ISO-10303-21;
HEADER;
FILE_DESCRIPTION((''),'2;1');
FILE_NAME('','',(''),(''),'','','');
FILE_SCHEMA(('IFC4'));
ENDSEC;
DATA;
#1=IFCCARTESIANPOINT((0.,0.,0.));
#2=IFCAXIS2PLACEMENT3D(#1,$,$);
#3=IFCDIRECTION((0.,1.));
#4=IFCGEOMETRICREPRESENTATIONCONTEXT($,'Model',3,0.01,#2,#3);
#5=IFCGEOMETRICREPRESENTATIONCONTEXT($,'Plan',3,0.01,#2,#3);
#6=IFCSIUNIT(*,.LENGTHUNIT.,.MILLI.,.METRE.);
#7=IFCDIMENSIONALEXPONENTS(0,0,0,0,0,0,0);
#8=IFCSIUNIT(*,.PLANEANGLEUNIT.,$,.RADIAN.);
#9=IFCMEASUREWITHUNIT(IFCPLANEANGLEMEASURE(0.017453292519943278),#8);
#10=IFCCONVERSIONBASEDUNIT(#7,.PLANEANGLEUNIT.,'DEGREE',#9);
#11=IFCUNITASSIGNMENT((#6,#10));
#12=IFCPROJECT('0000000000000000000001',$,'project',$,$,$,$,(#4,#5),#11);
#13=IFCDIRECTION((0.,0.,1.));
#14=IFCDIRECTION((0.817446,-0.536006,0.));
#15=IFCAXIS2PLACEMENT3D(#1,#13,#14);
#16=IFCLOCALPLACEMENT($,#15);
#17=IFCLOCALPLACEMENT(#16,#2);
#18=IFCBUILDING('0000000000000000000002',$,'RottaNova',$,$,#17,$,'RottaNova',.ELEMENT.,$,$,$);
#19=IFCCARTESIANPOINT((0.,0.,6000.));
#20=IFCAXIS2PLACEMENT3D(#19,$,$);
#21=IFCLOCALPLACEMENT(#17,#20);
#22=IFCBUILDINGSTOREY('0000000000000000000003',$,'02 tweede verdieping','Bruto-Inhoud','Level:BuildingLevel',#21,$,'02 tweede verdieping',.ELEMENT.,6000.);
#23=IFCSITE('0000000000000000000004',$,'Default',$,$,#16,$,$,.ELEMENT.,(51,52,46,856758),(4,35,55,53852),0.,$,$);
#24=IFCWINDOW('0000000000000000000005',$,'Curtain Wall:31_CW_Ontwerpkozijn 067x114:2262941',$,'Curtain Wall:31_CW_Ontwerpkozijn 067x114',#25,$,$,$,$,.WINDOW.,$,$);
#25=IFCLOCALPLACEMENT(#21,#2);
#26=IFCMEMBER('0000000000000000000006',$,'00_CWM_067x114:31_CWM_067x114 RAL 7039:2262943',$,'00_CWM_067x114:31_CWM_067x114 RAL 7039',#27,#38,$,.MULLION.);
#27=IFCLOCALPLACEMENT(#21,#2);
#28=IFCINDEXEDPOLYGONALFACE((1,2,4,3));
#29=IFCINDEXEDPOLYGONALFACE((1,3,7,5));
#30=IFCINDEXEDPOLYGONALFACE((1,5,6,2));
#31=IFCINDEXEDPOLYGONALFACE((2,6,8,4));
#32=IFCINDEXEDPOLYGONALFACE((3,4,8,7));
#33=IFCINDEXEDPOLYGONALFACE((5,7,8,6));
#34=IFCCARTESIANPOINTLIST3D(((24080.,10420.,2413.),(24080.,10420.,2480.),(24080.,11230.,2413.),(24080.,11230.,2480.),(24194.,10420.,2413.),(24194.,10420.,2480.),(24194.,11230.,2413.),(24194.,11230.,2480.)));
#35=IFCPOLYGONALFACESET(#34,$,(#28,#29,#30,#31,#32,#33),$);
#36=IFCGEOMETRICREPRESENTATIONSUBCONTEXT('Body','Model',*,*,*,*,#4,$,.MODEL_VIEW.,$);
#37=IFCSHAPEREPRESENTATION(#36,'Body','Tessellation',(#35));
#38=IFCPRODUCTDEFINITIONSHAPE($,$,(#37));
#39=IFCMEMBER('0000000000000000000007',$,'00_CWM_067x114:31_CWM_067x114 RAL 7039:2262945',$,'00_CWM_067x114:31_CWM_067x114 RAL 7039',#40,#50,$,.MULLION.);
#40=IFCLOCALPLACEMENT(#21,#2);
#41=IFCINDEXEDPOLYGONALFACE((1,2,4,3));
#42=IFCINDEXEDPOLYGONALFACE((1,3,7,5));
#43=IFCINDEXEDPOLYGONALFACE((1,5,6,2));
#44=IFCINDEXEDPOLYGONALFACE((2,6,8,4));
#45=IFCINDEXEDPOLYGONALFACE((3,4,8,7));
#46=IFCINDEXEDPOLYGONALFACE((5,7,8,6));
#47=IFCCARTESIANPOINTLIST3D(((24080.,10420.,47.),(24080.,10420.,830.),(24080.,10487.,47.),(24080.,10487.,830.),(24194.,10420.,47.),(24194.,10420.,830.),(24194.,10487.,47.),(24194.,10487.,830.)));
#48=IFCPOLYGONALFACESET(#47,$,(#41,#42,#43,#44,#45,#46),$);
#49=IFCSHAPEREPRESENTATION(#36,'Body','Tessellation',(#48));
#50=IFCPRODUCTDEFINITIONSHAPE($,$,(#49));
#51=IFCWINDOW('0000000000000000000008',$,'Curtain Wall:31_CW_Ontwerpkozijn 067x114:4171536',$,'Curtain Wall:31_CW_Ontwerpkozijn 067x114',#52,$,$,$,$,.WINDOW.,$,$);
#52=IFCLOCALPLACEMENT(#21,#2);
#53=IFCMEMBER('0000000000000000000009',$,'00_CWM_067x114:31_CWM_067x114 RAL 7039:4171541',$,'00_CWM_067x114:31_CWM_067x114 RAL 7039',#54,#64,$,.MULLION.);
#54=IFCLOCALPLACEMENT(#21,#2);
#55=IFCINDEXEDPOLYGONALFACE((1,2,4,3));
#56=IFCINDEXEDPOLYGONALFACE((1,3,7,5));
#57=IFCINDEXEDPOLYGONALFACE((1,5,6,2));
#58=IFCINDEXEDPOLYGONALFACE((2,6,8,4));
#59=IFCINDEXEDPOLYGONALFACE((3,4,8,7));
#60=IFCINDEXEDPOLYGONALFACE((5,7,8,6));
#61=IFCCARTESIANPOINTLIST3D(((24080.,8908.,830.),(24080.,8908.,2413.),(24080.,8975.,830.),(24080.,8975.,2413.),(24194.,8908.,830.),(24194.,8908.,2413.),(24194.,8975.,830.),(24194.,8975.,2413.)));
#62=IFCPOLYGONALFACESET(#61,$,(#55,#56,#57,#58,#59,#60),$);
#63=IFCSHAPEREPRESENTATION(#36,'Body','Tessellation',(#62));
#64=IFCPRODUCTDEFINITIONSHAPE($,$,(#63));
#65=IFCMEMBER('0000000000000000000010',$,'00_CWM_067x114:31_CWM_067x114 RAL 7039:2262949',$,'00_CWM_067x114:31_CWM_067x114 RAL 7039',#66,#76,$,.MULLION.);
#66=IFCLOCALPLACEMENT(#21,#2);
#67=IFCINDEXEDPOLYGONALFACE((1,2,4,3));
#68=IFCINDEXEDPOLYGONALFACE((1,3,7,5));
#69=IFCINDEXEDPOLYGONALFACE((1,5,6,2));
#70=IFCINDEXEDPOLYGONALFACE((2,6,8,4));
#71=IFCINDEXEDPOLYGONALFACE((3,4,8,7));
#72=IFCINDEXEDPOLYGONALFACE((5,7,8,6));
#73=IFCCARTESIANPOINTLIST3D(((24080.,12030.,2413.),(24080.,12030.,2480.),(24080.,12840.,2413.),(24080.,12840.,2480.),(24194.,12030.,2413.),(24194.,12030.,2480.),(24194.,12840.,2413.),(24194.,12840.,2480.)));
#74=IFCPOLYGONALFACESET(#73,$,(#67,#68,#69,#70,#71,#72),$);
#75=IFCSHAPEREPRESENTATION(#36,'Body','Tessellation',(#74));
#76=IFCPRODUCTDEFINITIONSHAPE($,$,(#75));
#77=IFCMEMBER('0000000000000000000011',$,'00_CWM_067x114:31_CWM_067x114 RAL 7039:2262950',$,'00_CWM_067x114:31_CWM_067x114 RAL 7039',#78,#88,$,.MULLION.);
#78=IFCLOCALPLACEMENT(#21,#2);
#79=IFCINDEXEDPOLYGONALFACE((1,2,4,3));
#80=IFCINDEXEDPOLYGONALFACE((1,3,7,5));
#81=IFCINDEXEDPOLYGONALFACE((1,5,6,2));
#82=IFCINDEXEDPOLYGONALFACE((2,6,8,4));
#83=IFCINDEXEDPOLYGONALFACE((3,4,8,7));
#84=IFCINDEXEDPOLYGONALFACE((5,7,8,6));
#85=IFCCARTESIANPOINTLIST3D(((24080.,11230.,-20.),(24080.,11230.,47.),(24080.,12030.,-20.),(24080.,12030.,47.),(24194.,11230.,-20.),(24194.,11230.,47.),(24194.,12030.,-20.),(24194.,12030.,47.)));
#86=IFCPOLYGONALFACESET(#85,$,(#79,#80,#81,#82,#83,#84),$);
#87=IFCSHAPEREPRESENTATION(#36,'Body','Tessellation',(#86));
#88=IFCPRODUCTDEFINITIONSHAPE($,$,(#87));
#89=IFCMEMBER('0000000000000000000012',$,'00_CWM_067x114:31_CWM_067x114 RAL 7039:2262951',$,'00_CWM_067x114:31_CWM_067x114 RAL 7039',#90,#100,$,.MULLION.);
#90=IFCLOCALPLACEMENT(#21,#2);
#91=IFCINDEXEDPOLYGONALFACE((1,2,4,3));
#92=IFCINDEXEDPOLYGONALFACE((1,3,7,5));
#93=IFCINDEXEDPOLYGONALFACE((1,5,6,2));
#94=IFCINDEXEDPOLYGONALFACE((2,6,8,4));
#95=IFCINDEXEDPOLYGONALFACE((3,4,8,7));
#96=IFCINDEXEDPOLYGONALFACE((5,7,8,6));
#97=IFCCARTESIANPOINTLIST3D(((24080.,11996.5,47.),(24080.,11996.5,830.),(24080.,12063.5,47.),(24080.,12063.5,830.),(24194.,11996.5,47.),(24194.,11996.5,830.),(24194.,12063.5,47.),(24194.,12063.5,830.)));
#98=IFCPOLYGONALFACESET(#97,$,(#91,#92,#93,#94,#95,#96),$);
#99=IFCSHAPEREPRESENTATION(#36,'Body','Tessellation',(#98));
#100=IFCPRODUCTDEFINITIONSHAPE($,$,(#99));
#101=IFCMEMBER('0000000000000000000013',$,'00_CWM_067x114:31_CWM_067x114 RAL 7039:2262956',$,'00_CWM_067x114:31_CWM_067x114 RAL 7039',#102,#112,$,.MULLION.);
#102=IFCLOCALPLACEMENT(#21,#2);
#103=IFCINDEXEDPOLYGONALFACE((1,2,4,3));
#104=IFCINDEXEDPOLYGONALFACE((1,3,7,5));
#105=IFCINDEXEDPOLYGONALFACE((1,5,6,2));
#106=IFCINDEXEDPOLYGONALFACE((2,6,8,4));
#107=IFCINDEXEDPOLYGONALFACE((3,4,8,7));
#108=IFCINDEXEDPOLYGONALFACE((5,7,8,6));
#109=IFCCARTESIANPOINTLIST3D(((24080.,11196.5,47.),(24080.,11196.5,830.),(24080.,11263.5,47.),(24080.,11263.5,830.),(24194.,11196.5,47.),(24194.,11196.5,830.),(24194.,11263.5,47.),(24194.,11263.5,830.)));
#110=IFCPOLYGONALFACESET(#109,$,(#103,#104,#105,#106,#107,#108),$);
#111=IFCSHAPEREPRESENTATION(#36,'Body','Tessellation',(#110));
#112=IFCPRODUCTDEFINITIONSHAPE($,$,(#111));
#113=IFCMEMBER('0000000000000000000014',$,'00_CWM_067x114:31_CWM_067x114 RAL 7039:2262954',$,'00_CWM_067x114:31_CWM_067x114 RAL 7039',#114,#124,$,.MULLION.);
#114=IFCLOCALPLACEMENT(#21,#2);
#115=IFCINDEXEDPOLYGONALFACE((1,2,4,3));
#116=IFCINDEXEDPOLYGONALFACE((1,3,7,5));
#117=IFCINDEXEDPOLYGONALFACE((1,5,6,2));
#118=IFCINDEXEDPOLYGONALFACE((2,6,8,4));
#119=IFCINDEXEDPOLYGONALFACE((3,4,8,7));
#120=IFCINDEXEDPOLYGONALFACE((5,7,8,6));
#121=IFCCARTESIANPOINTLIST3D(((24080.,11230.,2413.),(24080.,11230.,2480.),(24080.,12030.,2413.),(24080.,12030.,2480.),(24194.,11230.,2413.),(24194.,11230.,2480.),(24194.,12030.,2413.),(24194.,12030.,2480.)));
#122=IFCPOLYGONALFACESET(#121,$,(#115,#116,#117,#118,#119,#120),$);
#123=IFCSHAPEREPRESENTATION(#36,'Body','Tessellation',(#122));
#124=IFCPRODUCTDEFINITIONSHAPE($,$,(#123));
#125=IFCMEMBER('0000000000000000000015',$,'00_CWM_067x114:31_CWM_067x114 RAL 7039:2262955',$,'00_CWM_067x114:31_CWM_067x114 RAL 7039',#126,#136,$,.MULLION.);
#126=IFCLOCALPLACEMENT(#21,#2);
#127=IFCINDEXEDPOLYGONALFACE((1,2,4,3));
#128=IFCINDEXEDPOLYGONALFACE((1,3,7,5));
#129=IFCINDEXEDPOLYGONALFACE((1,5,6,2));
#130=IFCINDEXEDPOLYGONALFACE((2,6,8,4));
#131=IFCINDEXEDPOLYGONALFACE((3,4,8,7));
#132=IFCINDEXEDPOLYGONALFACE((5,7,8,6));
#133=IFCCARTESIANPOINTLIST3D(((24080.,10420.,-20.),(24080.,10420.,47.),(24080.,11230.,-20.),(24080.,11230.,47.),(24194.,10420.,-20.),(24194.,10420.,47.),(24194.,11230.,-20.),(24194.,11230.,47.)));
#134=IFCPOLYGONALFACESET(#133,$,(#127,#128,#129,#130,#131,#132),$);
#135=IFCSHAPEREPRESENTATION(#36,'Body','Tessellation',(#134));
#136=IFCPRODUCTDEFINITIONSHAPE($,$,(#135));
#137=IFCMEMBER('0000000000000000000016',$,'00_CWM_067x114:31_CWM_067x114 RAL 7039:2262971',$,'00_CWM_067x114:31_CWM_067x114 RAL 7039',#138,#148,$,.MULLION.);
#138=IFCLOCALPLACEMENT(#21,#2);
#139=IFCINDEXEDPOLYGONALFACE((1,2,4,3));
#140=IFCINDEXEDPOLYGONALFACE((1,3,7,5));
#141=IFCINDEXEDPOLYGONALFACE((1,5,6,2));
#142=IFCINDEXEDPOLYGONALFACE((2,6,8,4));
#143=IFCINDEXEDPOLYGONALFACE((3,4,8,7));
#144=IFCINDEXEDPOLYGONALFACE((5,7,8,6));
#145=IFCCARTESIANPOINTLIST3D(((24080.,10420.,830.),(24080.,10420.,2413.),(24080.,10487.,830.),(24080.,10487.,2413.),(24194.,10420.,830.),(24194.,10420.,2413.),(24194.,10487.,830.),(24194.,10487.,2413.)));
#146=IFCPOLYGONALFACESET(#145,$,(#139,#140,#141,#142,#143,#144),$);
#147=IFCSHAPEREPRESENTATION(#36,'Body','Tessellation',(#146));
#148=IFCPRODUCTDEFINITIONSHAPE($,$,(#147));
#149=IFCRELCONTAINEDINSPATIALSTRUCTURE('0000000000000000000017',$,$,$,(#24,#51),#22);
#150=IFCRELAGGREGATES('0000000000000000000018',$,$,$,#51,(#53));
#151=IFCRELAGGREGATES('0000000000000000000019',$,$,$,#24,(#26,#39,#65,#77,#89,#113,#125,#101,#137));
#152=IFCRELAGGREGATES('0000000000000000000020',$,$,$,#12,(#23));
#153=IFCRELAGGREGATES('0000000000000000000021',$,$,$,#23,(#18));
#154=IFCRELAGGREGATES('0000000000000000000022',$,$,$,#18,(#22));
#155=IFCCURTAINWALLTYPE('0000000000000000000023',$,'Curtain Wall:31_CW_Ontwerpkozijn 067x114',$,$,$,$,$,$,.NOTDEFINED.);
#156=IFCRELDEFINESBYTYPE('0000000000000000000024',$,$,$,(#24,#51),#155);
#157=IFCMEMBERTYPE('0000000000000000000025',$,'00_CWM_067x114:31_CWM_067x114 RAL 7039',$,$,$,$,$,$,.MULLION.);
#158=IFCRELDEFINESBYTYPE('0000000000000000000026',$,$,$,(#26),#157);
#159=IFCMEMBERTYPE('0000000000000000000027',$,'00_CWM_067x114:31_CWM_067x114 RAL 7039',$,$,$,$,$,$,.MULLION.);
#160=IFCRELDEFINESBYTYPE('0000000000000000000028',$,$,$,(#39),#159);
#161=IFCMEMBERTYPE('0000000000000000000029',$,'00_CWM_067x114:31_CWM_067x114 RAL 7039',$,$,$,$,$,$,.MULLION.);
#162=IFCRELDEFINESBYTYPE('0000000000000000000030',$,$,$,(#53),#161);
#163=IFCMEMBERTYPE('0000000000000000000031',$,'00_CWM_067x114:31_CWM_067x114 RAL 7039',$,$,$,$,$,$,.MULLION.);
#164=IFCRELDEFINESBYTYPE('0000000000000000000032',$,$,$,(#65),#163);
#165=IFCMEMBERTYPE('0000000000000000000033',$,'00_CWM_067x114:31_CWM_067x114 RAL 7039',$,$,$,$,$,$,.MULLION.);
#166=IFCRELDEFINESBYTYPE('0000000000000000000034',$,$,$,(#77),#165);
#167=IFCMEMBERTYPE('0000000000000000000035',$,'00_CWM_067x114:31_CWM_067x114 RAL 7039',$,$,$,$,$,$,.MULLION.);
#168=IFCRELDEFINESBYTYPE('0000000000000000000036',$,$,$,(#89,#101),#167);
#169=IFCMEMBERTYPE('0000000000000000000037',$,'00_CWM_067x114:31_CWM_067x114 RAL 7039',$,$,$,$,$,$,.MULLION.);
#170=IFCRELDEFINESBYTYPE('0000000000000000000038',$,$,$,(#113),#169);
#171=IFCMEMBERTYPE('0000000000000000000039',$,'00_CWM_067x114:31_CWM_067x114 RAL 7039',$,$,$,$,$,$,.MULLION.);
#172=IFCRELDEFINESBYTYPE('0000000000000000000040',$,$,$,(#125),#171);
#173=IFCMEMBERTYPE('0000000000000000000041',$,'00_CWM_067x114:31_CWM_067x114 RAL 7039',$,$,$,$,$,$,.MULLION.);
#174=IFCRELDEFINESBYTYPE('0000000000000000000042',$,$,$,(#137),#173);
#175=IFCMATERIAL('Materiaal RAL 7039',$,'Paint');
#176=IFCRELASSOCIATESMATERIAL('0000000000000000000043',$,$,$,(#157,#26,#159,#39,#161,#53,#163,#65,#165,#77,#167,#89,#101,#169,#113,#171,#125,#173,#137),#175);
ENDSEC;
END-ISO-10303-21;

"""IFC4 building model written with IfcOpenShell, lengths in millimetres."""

from ifc_helpers import new_model, entity, si_unit, converted_unit, direction, frame, origin, place, context, subcontext, project, spatial, indexed_curve, outline, extrude, source, transform, mapped, material, type_object, type_shapes, element, aggregate, save


model = new_model("IFC4")

# Units and contexts
model_context = context("Model", 3, precision=0.01, world=origin(), true_north=direction((0.0, 1.0)))
plan_context = context("Plan", 3, precision=0.01, world=origin(), true_north=direction((0.0, 1.0)))
body_context = subcontext(model_context, "Body", "Model", "MODEL_VIEW")
ifc_project = project(units=[si_unit("LENGTHUNIT", "METRE", prefix="MILLI"), converted_unit("PLANEANGLEUNIT", "DEGREE", entity("IfcPlaneAngleMeasure", 0.017453292519943278), si_unit("PLANEANGLEUNIT", "RADIAN"), dimensions=[0, 0, 0, 0, 0, 0, 0])], contexts=[model_context, plan_context])

# Site, building, storey
site_placement = place(None, frame((0.0, 0.0, 0.0), z_axis=(0.0, 0.0, 1.0), x_axis=(0.817446, -0.536006, 0.0)))
site = spatial("IfcSite", under=ifc_project, at=site_placement, Name="Default", CompositionType="ELEMENT", RefLatitude=(51, 52, 46, 856758), RefLongitude=(4, 35, 55, 53852), RefElevation=0.0)
building_placement = place(site_placement, origin())
building = spatial("IfcBuilding", under=site, at=building_placement, Name="RottaNova", LongName="RottaNova", CompositionType="ELEMENT")
storey_placement = place(building_placement, frame((0.0, 0.0, 6000.0)))
storey = spatial("IfcBuildingStorey", under=building, at=storey_placement, Name="02 tweede verdieping", Description="Bruto-Inhoud", ObjectType="Level:BuildingLevel", LongName="02 tweede verdieping", CompositionType="ELEMENT", Elevation=6000.0)

# Window, members
curtain_wall_type = type_object("IfcCurtainWallType", Name="Curtain Wall:31_CW_Ontwerpkozijn 067x114", PredefinedType="NOTDEFINED")
window_1_placement = place(storey_placement, frame((0.0, 0.0, -6000.0)))
window_1 = element("IfcWindow", 1, at=window_1_placement, inside=storey, type_object=curtain_wall_type, Name="Curtain Wall:31_CW_Ontwerpkozijn 067x114:2262941", ObjectType="Curtain Wall:31_CW_Ontwerpkozijn 067x114", PredefinedType="WINDOW")
ifc_material_1 = material(Name="Materiaal RAL 7039", Category="Paint")
member_type_1 = type_object("IfcMemberType", Name="00_CWM_067x114:31_CWM_067x114 RAL 7039", PredefinedType="MULLION", material=ifc_material_1)
shared_shape_1 = source(origin(), body_context, "Body", "SweptSolid", [
    extrude(outline(indexed_curve([(-33.5, -57.0), (33.5, -57.0), (33.5, 57.0), (-33.5, 57.0), (-33.5, -57.0)], self_intersect=False)), frame((-33.5, -57.0, -810.0), z_axis=(0.0, 0.0, 1.0), x_axis=(-1.0, 0.0, 0.0)), (0.0, 0.0, 1.0), 810.0),
])
type_shapes(member_type_1, [shared_shape_1])
member_1_placement = place(window_1_placement, frame((24080.0, 10420.0, 8480.0), z_axis=(0.0, -1.0, 0.0), x_axis=(0.0, 0.0, 1.0)))
member_1 = element("IfcMember", 2, at=member_1_placement, type_object=member_type_1, material=ifc_material_1, Name="00_CWM_067x114:31_CWM_067x114 RAL 7039:2262943", ObjectType="00_CWM_067x114:31_CWM_067x114 RAL 7039", PredefinedType="MULLION", context=body_context, shape_type="MappedRepresentation", body=[
    mapped(shared_shape_1, transform((0.0, 0.0, 0.0), scale=1.0)),
])
member_type_2 = type_object("IfcMemberType", Name="00_CWM_067x114:31_CWM_067x114 RAL 7039", PredefinedType="MULLION", material=ifc_material_1)
shared_shape_2 = source(origin(), body_context, "Body", "SweptSolid", [
    extrude(outline(indexed_curve([(-33.5, -57.0), (33.5, -57.0), (33.5, 57.0), (-33.5, 57.0), (-33.5, -57.0)], self_intersect=False)), frame((-33.5, -57.0, -783.0), z_axis=(0.0, 0.0, 1.0), x_axis=(-1.0, 0.0, 0.0)), (0.0, 0.0, 1.0), 783.0),
])
type_shapes(member_type_2, [shared_shape_2])
member_2_placement = place(window_1_placement, frame((24080.0, 10420.0, 6047.0), z_axis=(0.0, 0.0, -1.0), x_axis=(0.0, -1.0, 0.0)))
member_2 = element("IfcMember", 3, at=member_2_placement, type_object=member_type_2, material=ifc_material_1, Name="00_CWM_067x114:31_CWM_067x114 RAL 7039:2262945", ObjectType="00_CWM_067x114:31_CWM_067x114 RAL 7039", PredefinedType="MULLION", context=body_context, shape_type="MappedRepresentation", body=[
    mapped(shared_shape_2, transform((0.0, 0.0, 0.0), scale=1.0)),
])

# Window, member
window_2_placement = place(storey_placement, frame((0.0, 0.0, -6000.0)))
window_2 = element("IfcWindow", 4, at=window_2_placement, inside=storey, type_object=curtain_wall_type, Name="Curtain Wall:31_CW_Ontwerpkozijn 067x114:4171536", ObjectType="Curtain Wall:31_CW_Ontwerpkozijn 067x114", PredefinedType="WINDOW")
member_type_3 = type_object("IfcMemberType", Name="00_CWM_067x114:31_CWM_067x114 RAL 7039", PredefinedType="MULLION", material=ifc_material_1)
shared_shape_3 = source(origin(), body_context, "Body", "SweptSolid", [
    extrude(outline(indexed_curve([(-33.5, -57.0), (33.5, -57.0), (33.5, 57.0), (-33.5, 57.0), (-33.5, -57.0)], self_intersect=False)), frame((-33.5, -57.0, -1583.0), z_axis=(0.0, 0.0, 1.0), x_axis=(-1.0, 0.0, 0.0)), (0.0, 0.0, 1.0), 1583.0),
])
type_shapes(member_type_3, [shared_shape_3])
member_3_placement = place(window_2_placement, frame((24080.0, 8975.0, 8413.0), z_axis=(0.0, 0.0, 1.0), x_axis=(0.0, 1.0, 0.0)))
member_3 = element("IfcMember", 5, at=member_3_placement, type_object=member_type_3, material=ifc_material_1, Name="00_CWM_067x114:31_CWM_067x114 RAL 7039:4171541", ObjectType="00_CWM_067x114:31_CWM_067x114 RAL 7039", PredefinedType="MULLION", context=body_context, shape_type="MappedRepresentation", body=[
    mapped(shared_shape_3, transform((0.0, 0.0, 0.0), scale=1.0)),
])

# Members
member_type_4 = type_object("IfcMemberType", Name="00_CWM_067x114:31_CWM_067x114 RAL 7039", PredefinedType="MULLION", material=ifc_material_1)
shared_shape_4 = source(origin(), body_context, "Body", "SweptSolid", [
    extrude(outline(indexed_curve([(-33.5, -57.0), (33.5, -57.0), (33.5, 57.0), (-33.5, 57.0), (-33.5, -57.0)], self_intersect=False)), frame((-33.5, -57.0, -810.0), z_axis=(0.0, 0.0, 1.0), x_axis=(-1.0, 0.0, 0.0)), (0.0, 0.0, 1.0), 810.0),
])
type_shapes(member_type_4, [shared_shape_4])
member_4_placement = place(window_1_placement, frame((24080.0, 12030.0, 8480.0), z_axis=(0.0, -1.0, 0.0), x_axis=(0.0, 0.0, 1.0)))
member_4 = element("IfcMember", 6, at=member_4_placement, type_object=member_type_4, material=ifc_material_1, Name="00_CWM_067x114:31_CWM_067x114 RAL 7039:2262949", ObjectType="00_CWM_067x114:31_CWM_067x114 RAL 7039", PredefinedType="MULLION", context=body_context, shape_type="MappedRepresentation", body=[
    mapped(shared_shape_4, transform((0.0, 0.0, 0.0), scale=1.0)),
])
member_type_5 = type_object("IfcMemberType", Name="00_CWM_067x114:31_CWM_067x114 RAL 7039", PredefinedType="MULLION", material=ifc_material_1)
shared_shape_5 = source(origin(), body_context, "Body", "SweptSolid", [
    extrude(outline(indexed_curve([(-33.5, -57.0), (33.5, -57.0), (33.5, 57.0), (-33.5, 57.0), (-33.5, -57.0)], self_intersect=False)), frame((-33.5, -57.0, -800.0), z_axis=(0.0, 0.0, 1.0), x_axis=(-1.0, 0.0, 0.0)), (0.0, 0.0, 1.0), 800.0),
])
type_shapes(member_type_5, [shared_shape_5])
member_5_placement = place(window_1_placement, frame((24080.0, 12030.0, 5980.0), z_axis=(0.0, 1.0, 0.0), x_axis=(0.0, 0.0, -1.0)))
member_5 = element("IfcMember", 7, at=member_5_placement, type_object=member_type_5, material=ifc_material_1, Name="00_CWM_067x114:31_CWM_067x114 RAL 7039:2262950", ObjectType="00_CWM_067x114:31_CWM_067x114 RAL 7039", PredefinedType="MULLION", context=body_context, shape_type="MappedRepresentation", body=[
    mapped(shared_shape_5, transform((0.0, 0.0, 0.0), scale=1.0)),
])
member_type_6 = type_object("IfcMemberType", Name="00_CWM_067x114:31_CWM_067x114 RAL 7039", PredefinedType="MULLION", material=ifc_material_1)
shared_shape_6 = source(origin(), body_context, "Body", "SweptSolid", [
    extrude(outline(indexed_curve([(-33.5, -57.0), (33.5, -57.0), (33.5, 57.0), (-33.5, 57.0), (-33.5, -57.0)], self_intersect=False)), frame((0.0, -57.0, -783.0), z_axis=(0.0, 0.0, 1.0), x_axis=(-1.0, 0.0, 0.0)), (0.0, 0.0, 1.0), 783.0),
])
type_shapes(member_type_6, [shared_shape_6])
member_6_placement = place(window_1_placement, frame((24080.0, 12030.0, 6047.0), z_axis=(0.0, 0.0, -1.0), x_axis=(0.0, -1.0, 0.0)))
member_6 = element("IfcMember", 8, at=member_6_placement, type_object=member_type_6, material=ifc_material_1, Name="00_CWM_067x114:31_CWM_067x114 RAL 7039:2262951", ObjectType="00_CWM_067x114:31_CWM_067x114 RAL 7039", PredefinedType="MULLION", context=body_context, shape_type="MappedRepresentation", body=[
    mapped(shared_shape_6, transform((0.0, 0.0, 0.0), scale=1.0)),
])
member_7_placement = place(window_1_placement, frame((24080.0, 11230.0, 6047.0), z_axis=(0.0, 0.0, -1.0), x_axis=(0.0, -1.0, 0.0)))
member_7 = element("IfcMember", 9, at=member_7_placement, type_object=member_type_6, material=ifc_material_1, Name="00_CWM_067x114:31_CWM_067x114 RAL 7039:2262956", ObjectType="00_CWM_067x114:31_CWM_067x114 RAL 7039", PredefinedType="MULLION", context=body_context, shape_type="MappedRepresentation", body=[
    mapped(shared_shape_6, transform((0.0, 0.0, 0.0), scale=1.0)),
])
member_type_7 = type_object("IfcMemberType", Name="00_CWM_067x114:31_CWM_067x114 RAL 7039", PredefinedType="MULLION", material=ifc_material_1)
shared_shape_7 = source(origin(), body_context, "Body", "SweptSolid", [
    extrude(outline(indexed_curve([(-33.5, -57.0), (33.5, -57.0), (33.5, 57.0), (-33.5, 57.0), (-33.5, -57.0)], self_intersect=False)), frame((-33.5, -57.0, -800.0), z_axis=(0.0, 0.0, 1.0), x_axis=(-1.0, 0.0, 0.0)), (0.0, 0.0, 1.0), 800.0),
])
type_shapes(member_type_7, [shared_shape_7])
member_8_placement = place(window_1_placement, frame((24080.0, 11230.0, 8480.0), z_axis=(0.0, -1.0, 0.0), x_axis=(0.0, 0.0, 1.0)))
member_8 = element("IfcMember", 10, at=member_8_placement, type_object=member_type_7, material=ifc_material_1, Name="00_CWM_067x114:31_CWM_067x114 RAL 7039:2262954", ObjectType="00_CWM_067x114:31_CWM_067x114 RAL 7039", PredefinedType="MULLION", context=body_context, shape_type="MappedRepresentation", body=[
    mapped(shared_shape_7, transform((0.0, 0.0, 0.0), scale=1.0)),
])
member_type_8 = type_object("IfcMemberType", Name="00_CWM_067x114:31_CWM_067x114 RAL 7039", PredefinedType="MULLION", material=ifc_material_1)
shared_shape_8 = source(origin(), body_context, "Body", "SweptSolid", [
    extrude(outline(indexed_curve([(-33.5, -57.0), (33.5, -57.0), (33.5, 57.0), (-33.5, 57.0), (-33.5, -57.0)], self_intersect=False)), frame((-33.5, -57.0, -810.0), z_axis=(0.0, 0.0, 1.0), x_axis=(-1.0, 0.0, 0.0)), (0.0, 0.0, 1.0), 810.0),
])
type_shapes(member_type_8, [shared_shape_8])
member_9_placement = place(window_1_placement, frame((24080.0, 11230.0, 5980.0), z_axis=(0.0, 1.0, 0.0), x_axis=(0.0, 0.0, -1.0)))
member_9 = element("IfcMember", 11, at=member_9_placement, type_object=member_type_8, material=ifc_material_1, Name="00_CWM_067x114:31_CWM_067x114 RAL 7039:2262955", ObjectType="00_CWM_067x114:31_CWM_067x114 RAL 7039", PredefinedType="MULLION", context=body_context, shape_type="MappedRepresentation", body=[
    mapped(shared_shape_8, transform((0.0, 0.0, 0.0), scale=1.0)),
])
member_type_9 = type_object("IfcMemberType", Name="00_CWM_067x114:31_CWM_067x114 RAL 7039", PredefinedType="MULLION", material=ifc_material_1)
shared_shape_9 = source(origin(), body_context, "Body", "SweptSolid", [
    extrude(outline(indexed_curve([(-33.5, -57.0), (33.5, -57.0), (33.5, 57.0), (-33.5, 57.0), (-33.5, -57.0)], self_intersect=False)), frame((-33.5, -57.0, -1583.0), z_axis=(0.0, 0.0, 1.0), x_axis=(-1.0, 0.0, 0.0)), (0.0, 0.0, 1.0), 1583.0),
])
type_shapes(member_type_9, [shared_shape_9])
member_10_placement = place(window_1_placement, frame((24080.0, 10420.0, 6830.0), z_axis=(0.0, 0.0, -1.0), x_axis=(0.0, -1.0, 0.0)))
member_10 = element("IfcMember", 12, at=member_10_placement, type_object=member_type_9, material=ifc_material_1, Name="00_CWM_067x114:31_CWM_067x114 RAL 7039:2262971", ObjectType="00_CWM_067x114:31_CWM_067x114 RAL 7039", PredefinedType="MULLION", context=body_context, shape_type="MappedRepresentation", body=[
    mapped(shared_shape_9, transform((0.0, 0.0, 0.0), scale=1.0)),
])
aggregate(window_2, [member_3])

aggregate(window_1, [member_1, member_2, member_4, member_5, member_6, member_8, member_9, member_7, member_10])

save(model, "model.ifc")
